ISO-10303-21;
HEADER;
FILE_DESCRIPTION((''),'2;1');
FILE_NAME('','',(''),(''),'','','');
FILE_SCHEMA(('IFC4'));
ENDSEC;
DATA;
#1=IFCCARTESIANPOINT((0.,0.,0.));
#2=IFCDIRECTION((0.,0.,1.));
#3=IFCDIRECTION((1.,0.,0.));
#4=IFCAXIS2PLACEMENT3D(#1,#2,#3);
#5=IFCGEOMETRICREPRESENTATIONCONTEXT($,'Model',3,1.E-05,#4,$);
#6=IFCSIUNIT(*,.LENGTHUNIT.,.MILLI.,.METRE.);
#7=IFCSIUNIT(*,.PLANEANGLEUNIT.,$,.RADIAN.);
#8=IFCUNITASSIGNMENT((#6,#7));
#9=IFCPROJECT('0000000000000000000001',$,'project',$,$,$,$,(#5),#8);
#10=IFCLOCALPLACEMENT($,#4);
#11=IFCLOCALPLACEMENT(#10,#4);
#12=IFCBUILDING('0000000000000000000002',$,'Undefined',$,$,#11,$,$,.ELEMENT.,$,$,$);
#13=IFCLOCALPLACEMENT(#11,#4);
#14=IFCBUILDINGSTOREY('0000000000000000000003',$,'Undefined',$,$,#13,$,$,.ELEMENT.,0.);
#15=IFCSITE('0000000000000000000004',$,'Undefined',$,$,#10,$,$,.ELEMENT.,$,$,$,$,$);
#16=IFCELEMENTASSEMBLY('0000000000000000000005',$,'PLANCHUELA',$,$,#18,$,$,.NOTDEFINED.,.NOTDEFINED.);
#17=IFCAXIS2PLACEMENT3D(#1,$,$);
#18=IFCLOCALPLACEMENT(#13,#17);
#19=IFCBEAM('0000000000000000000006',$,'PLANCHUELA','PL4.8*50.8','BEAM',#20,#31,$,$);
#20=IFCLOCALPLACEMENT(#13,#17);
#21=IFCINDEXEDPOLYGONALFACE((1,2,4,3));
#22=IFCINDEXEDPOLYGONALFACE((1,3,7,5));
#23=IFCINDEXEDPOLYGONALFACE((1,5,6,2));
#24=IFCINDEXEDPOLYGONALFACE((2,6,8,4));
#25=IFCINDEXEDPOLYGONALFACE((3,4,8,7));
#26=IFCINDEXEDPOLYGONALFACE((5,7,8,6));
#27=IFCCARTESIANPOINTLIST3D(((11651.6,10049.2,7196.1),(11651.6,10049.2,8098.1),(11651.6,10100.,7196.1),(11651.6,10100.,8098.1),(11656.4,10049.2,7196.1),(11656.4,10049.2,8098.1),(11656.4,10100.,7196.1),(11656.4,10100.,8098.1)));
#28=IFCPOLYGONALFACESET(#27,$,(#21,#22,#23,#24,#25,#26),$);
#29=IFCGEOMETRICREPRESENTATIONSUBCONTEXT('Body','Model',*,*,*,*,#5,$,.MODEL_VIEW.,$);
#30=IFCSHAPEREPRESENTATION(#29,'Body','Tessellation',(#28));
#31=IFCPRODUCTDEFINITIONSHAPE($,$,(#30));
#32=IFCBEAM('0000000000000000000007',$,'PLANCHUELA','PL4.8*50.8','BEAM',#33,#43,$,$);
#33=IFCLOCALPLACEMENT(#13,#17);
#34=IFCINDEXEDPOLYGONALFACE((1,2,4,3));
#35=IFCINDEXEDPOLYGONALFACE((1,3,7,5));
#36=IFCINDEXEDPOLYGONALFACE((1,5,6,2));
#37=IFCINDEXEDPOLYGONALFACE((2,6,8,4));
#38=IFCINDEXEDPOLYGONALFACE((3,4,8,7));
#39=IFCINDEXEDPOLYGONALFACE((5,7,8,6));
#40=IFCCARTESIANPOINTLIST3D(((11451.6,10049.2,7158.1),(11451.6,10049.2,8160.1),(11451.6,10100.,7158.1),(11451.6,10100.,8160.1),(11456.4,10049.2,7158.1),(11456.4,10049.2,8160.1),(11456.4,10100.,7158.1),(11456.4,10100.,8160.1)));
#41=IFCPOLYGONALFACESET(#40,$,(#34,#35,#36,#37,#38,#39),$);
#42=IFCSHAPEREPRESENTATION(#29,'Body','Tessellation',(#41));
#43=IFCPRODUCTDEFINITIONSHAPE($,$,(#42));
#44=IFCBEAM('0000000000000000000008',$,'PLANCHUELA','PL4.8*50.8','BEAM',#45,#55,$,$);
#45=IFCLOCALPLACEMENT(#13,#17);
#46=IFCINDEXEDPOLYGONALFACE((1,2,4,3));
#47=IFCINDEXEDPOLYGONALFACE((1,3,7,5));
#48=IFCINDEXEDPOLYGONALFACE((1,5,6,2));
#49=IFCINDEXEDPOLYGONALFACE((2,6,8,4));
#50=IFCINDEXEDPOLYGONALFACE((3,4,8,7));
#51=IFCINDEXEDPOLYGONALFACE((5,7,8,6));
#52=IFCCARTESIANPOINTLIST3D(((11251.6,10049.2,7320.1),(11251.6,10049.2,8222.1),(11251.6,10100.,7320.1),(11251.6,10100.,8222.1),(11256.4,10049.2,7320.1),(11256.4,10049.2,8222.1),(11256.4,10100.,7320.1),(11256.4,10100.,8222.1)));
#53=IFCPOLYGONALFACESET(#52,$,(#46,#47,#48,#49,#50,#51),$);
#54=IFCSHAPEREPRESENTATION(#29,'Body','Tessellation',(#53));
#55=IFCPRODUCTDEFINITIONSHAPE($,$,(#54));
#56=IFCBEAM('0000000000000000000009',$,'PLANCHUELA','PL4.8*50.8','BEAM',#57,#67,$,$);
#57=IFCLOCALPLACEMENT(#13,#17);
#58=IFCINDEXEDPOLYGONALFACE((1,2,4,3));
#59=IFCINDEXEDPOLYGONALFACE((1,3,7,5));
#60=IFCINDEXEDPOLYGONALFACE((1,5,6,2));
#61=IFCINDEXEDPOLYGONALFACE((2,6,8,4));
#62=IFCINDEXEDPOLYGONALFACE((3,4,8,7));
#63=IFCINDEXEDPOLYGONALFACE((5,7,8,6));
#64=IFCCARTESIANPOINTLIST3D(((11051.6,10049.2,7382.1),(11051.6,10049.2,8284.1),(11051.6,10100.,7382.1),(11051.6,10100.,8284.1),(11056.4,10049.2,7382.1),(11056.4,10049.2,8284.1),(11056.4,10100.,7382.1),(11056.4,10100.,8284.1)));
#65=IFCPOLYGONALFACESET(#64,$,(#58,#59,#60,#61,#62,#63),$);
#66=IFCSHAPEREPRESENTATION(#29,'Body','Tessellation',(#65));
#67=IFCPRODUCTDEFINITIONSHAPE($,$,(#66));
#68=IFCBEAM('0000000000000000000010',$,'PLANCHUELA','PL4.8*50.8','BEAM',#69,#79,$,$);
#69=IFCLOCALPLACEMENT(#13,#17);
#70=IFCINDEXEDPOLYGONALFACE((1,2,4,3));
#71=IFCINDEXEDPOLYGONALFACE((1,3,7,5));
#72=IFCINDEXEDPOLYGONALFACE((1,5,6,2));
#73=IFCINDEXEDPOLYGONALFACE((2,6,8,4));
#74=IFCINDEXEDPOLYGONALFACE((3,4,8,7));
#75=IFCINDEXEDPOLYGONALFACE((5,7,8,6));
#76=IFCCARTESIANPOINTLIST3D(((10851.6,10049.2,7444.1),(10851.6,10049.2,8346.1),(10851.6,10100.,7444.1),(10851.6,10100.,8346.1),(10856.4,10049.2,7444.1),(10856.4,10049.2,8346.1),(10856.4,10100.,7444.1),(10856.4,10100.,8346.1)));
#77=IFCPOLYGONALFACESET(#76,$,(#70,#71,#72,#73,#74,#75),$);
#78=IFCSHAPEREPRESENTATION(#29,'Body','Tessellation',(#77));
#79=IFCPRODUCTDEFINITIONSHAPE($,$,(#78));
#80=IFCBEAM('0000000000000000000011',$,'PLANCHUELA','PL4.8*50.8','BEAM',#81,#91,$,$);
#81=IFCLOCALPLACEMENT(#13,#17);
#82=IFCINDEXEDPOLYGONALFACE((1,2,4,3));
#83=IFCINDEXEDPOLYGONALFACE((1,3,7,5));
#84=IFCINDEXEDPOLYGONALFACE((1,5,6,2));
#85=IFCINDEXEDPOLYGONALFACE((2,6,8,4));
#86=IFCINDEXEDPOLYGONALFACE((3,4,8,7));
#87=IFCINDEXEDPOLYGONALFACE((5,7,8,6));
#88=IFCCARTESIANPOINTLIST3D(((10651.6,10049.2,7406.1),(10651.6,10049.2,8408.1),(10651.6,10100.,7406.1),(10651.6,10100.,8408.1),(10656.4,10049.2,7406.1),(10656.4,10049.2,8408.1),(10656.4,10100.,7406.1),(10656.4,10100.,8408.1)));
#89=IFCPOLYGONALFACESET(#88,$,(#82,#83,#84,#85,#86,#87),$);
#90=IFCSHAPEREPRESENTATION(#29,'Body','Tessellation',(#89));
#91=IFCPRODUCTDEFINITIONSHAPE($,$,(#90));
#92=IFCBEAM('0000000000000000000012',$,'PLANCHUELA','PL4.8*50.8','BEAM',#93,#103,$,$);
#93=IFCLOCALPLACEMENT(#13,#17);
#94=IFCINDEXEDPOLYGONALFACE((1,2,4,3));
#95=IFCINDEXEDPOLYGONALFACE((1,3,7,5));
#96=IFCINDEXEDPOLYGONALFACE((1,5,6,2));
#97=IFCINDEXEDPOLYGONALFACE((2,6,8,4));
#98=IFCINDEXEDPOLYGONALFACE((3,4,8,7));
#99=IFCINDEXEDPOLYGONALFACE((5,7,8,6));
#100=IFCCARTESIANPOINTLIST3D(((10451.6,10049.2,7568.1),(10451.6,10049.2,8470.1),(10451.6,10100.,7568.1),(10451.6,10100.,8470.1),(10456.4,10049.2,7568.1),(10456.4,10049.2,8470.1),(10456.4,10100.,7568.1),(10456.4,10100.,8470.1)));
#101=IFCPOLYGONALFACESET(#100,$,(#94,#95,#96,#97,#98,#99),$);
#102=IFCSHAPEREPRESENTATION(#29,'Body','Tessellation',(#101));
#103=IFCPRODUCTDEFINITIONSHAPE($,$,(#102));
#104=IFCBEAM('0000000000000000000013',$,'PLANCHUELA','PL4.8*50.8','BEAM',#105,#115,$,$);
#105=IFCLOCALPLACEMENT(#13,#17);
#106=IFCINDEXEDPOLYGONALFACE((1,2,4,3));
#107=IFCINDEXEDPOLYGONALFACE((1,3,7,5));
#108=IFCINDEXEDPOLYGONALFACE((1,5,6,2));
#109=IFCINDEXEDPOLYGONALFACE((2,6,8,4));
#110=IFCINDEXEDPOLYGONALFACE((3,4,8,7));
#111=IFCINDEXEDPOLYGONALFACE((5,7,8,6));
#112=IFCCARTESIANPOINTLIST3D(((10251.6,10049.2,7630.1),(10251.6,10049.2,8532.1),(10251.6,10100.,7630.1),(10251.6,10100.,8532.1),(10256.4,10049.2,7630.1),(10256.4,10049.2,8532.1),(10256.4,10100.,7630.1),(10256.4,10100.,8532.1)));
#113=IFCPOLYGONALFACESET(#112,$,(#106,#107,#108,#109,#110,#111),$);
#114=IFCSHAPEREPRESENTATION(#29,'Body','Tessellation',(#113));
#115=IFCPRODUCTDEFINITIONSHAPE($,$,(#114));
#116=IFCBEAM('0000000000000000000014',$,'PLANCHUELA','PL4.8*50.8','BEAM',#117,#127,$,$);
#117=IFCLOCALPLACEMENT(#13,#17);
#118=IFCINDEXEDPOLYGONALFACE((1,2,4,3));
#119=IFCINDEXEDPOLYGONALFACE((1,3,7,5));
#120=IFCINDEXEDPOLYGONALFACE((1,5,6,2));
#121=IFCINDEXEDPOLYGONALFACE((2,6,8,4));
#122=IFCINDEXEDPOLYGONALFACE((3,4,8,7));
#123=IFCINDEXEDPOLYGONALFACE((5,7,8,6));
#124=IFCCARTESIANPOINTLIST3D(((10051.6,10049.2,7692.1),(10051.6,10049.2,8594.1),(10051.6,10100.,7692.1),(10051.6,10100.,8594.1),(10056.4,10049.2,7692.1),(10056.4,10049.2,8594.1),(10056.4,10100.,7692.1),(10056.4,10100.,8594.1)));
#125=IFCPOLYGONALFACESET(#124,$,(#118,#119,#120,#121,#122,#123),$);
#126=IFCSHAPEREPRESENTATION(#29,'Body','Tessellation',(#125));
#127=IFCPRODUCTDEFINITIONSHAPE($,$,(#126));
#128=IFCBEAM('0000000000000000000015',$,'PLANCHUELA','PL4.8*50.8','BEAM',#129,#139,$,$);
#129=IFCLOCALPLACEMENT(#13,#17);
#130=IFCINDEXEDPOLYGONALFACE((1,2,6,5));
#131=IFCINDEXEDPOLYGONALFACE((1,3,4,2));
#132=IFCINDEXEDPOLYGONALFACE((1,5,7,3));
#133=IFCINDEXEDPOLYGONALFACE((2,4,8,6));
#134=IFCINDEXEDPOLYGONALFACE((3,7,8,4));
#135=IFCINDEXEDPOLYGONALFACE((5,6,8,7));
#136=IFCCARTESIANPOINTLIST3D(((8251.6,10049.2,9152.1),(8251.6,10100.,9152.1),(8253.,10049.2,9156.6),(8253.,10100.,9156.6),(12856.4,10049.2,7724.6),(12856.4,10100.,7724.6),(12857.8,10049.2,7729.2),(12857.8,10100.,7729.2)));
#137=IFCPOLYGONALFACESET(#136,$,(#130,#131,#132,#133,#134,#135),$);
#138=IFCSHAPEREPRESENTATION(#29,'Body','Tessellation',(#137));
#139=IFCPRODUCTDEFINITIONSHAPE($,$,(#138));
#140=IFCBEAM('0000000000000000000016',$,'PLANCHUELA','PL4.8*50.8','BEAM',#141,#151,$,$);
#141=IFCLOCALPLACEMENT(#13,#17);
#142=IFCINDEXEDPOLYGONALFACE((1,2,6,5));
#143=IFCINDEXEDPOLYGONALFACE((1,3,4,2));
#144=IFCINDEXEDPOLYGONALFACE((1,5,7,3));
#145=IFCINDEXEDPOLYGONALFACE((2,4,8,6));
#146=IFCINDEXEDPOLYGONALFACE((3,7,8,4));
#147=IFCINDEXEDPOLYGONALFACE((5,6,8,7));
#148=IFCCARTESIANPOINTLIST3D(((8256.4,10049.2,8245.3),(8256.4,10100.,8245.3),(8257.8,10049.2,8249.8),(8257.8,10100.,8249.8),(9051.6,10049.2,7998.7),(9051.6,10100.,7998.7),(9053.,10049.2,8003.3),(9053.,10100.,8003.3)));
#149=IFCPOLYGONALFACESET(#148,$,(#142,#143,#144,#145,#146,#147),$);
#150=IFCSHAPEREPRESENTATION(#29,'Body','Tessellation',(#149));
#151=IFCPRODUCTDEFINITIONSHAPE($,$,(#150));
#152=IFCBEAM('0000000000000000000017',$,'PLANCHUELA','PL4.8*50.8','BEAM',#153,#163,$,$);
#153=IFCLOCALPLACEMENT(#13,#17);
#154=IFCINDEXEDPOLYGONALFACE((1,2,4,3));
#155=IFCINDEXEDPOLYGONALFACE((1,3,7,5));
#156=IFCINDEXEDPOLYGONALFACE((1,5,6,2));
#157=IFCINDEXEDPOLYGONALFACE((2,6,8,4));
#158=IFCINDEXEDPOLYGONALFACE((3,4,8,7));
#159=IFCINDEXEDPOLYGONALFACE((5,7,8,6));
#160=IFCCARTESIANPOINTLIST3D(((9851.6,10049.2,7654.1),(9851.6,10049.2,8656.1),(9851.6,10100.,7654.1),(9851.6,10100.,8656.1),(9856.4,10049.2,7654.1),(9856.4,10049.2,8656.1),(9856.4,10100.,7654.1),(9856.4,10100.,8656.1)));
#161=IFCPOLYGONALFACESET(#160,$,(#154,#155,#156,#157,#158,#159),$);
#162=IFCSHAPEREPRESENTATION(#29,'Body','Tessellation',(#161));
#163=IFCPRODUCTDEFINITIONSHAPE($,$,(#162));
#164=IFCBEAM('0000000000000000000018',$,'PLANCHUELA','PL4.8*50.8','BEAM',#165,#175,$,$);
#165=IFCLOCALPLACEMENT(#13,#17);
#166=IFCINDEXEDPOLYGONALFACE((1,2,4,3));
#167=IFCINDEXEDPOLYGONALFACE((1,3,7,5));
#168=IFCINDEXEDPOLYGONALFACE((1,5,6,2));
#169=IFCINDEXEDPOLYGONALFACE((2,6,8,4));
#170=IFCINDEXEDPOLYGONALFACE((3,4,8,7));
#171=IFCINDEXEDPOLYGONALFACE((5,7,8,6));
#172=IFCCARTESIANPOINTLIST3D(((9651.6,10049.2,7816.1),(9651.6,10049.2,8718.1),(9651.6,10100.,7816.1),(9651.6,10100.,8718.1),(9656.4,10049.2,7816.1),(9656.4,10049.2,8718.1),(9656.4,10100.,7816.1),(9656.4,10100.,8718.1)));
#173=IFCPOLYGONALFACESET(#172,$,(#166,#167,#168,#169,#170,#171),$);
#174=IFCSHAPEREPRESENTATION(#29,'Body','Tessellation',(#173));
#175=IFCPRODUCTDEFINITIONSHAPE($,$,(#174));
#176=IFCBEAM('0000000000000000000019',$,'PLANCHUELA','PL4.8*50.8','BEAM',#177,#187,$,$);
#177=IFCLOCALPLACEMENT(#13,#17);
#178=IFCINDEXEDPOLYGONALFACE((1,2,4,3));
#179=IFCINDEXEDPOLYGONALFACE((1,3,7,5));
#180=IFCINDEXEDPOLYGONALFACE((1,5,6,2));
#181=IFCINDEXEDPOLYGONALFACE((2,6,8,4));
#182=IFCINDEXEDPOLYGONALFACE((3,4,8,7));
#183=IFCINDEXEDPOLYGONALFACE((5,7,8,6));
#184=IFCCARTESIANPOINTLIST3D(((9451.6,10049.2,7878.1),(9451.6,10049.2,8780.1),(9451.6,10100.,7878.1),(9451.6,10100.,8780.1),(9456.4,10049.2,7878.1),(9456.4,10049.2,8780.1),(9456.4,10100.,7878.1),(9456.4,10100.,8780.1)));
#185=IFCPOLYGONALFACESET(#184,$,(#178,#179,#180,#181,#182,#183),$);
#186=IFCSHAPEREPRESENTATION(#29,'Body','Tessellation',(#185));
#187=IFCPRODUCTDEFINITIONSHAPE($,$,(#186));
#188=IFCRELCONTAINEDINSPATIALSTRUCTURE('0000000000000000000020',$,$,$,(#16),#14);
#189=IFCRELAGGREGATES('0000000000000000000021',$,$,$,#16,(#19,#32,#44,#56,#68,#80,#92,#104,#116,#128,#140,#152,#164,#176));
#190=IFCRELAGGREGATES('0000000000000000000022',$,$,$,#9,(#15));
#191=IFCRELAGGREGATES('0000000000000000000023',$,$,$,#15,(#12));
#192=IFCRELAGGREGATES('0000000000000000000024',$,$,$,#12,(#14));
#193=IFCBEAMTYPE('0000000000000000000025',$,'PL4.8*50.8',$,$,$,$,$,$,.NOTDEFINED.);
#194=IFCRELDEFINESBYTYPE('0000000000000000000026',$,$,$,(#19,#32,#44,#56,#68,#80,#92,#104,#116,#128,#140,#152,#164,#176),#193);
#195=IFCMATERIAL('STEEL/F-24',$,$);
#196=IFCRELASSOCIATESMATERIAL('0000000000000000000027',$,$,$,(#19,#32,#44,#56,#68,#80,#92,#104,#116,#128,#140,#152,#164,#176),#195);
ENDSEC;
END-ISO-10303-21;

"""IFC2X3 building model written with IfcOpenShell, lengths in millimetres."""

from ifc_helpers import new_model, si_unit, frame, origin_with_axes, origin_2d_with_axis, place, context, subcontext, project, spatial, rectangle, extrude, material, type_object, element, aggregate, save


model = new_model("IFC2X3")

# Units and contexts
model_context = context("Model", 3, precision=1e-05, world=origin_with_axes())
body_context = subcontext(model_context, "Body", "Model", "MODEL_VIEW")
ifc_project = project(units=[si_unit("LENGTHUNIT", "METRE", prefix="MILLI"), si_unit("PLANEANGLEUNIT", "RADIAN")], contexts=[model_context])

# Site, building, storey
site_placement = place(None, origin_with_axes())
site = spatial("IfcSite", under=ifc_project, at=site_placement, Name="Undefined", CompositionType="ELEMENT")
building_placement = place(site_placement, origin_with_axes())
building = spatial("IfcBuilding", under=site, at=building_placement, Name="Undefined", CompositionType="ELEMENT")
storey_placement = place(building_placement, origin_with_axes())
storey = spatial("IfcBuildingStorey", under=building, at=storey_placement, Name="Undefined", CompositionType="ELEMENT", Elevation=0.0)

# Element assembly, beams
assembly_1_placement = place(storey_placement, origin_with_axes())
assembly_1 = element("IfcElementAssembly", 1, at=assembly_1_placement, inside=storey, Name="PLANCHUELA", AssemblyPlace="NOTDEFINED", PredefinedType="NOTDEFINED")
ifc_material_1 = material(Name="STEEL/F-24")
beam_type = type_object("IfcBeamType", Name="PL4.8*50.8", PredefinedType="NOTDEFINED")
beam_1_placement = place(assembly_1_placement, frame((11654.0, 10074.6, 8098.1), z_axis=(0.0, -1.0, 0.0), x_axis=(0.0, 0.0, -1.0)))
beam_1 = element("IfcBeam", 2, at=beam_1_placement, type_object=beam_type, material=ifc_material_1, Name="PLANCHUELA", Description="PL4.8*50.8", ObjectType="BEAM", context=body_context, shape_type="SweptSolid", body=[
    extrude(rectangle(XDim=4.8, YDim=50.8, at=origin_2d_with_axis()), frame((902.0, 0.0, 0.0), z_axis=(-1.0, 0.0, 0.0), x_axis=(0.0, -1.0, 0.0)), (0.0, 0.0, 1.0), 902.0),
])
beam_2_placement = place(assembly_1_placement, frame((11454.0, 10074.6, 8160.1), z_axis=(0.0, -1.0, 0.0), x_axis=(0.0, 0.0, -1.0)))
beam_2 = element("IfcBeam", 3, at=beam_2_placement, type_object=beam_type, material=ifc_material_1, Name="PLANCHUELA", Description="PL4.8*50.8", ObjectType="BEAM", context=body_context, shape_type="SweptSolid", body=[
    extrude(rectangle(XDim=4.8, YDim=50.8, at=origin_2d_with_axis()), frame((1002.0, 0.0, 0.0), z_axis=(-1.0, 0.0, 0.0), x_axis=(0.0, -1.0, 0.0)), (0.0, 0.0, 1.0), 1002.0),
])
beam_3_placement = place(assembly_1_placement, frame((11254.0, 10074.6, 8222.1), z_axis=(0.0, -1.0, 0.0), x_axis=(0.0, 0.0, -1.0)))
beam_3 = element("IfcBeam", 4, at=beam_3_placement, type_object=beam_type, material=ifc_material_1, Name="PLANCHUELA", Description="PL4.8*50.8", ObjectType="BEAM", context=body_context, shape_type="SweptSolid", body=[
    extrude(rectangle(XDim=4.8, YDim=50.8, at=origin_2d_with_axis()), frame((902.0, 0.0, 0.0), z_axis=(-1.0, 0.0, 0.0), x_axis=(0.0, -1.0, 0.0)), (0.0, 0.0, 1.0), 902.0),
])
beam_4_placement = place(assembly_1_placement, frame((11054.0, 10074.6, 8284.1), z_axis=(0.0, -1.0, 0.0), x_axis=(0.0, 0.0, -1.0)))
beam_4 = element("IfcBeam", 5, at=beam_4_placement, type_object=beam_type, material=ifc_material_1, Name="PLANCHUELA", Description="PL4.8*50.8", ObjectType="BEAM", context=body_context, shape_type="SweptSolid", body=[
    extrude(rectangle(XDim=4.8, YDim=50.8, at=origin_2d_with_axis()), frame((902.0, 0.0, 0.0), z_axis=(-1.0, 0.0, 0.0), x_axis=(0.0, -1.0, 0.0)), (0.0, 0.0, 1.0), 902.0),
])
beam_5_placement = place(assembly_1_placement, frame((10854.0, 10074.6, 8346.1), z_axis=(0.0, -1.0, 0.0), x_axis=(0.0, 0.0, -1.0)))
beam_5 = element("IfcBeam", 6, at=beam_5_placement, type_object=beam_type, material=ifc_material_1, Name="PLANCHUELA", Description="PL4.8*50.8", ObjectType="BEAM", context=body_context, shape_type="SweptSolid", body=[
    extrude(rectangle(XDim=4.8, YDim=50.8, at=origin_2d_with_axis()), frame((902.0, 0.0, 0.0), z_axis=(-1.0, 0.0, 0.0), x_axis=(0.0, -1.0, 0.0)), (0.0, 0.0, 1.0), 902.0),
])
beam_6_placement = place(assembly_1_placement, frame((10654.0, 10074.6, 8408.1), z_axis=(0.0, -1.0, 0.0), x_axis=(0.0, 0.0, -1.0)))
beam_6 = element("IfcBeam", 7, at=beam_6_placement, type_object=beam_type, material=ifc_material_1, Name="PLANCHUELA", Description="PL4.8*50.8", ObjectType="BEAM", context=body_context, shape_type="SweptSolid", body=[
    extrude(rectangle(XDim=4.8, YDim=50.8, at=origin_2d_with_axis()), frame((1002.0, 0.0, 0.0), z_axis=(-1.0, 0.0, 0.0), x_axis=(0.0, -1.0, 0.0)), (0.0, 0.0, 1.0), 1002.0),
])
beam_7_placement = place(assembly_1_placement, frame((10454.0, 10074.6, 8470.1), z_axis=(0.0, -1.0, 0.0), x_axis=(0.0, 0.0, -1.0)))
beam_7 = element("IfcBeam", 8, at=beam_7_placement, type_object=beam_type, material=ifc_material_1, Name="PLANCHUELA", Description="PL4.8*50.8", ObjectType="BEAM", context=body_context, shape_type="SweptSolid", body=[
    extrude(rectangle(XDim=4.8, YDim=50.8, at=origin_2d_with_axis()), frame((902.0, 0.0, 0.0), z_axis=(-1.0, 0.0, 0.0), x_axis=(0.0, -1.0, 0.0)), (0.0, 0.0, 1.0), 902.0),
])
beam_8_placement = place(assembly_1_placement, frame((10254.0, 10074.6, 8532.1), z_axis=(0.0, -1.0, 0.0), x_axis=(0.0, 0.0, -1.0)))
beam_8 = element("IfcBeam", 9, at=beam_8_placement, type_object=beam_type, material=ifc_material_1, Name="PLANCHUELA", Description="PL4.8*50.8", ObjectType="BEAM", context=body_context, shape_type="SweptSolid", body=[
    extrude(rectangle(XDim=4.8, YDim=50.8, at=origin_2d_with_axis()), frame((902.0, 0.0, 0.0), z_axis=(-1.0, 0.0, 0.0), x_axis=(0.0, -1.0, 0.0)), (0.0, 0.0, 1.0), 902.0),
])
beam_9_placement = place(assembly_1_placement, frame((10054.0, 10074.6, 8594.1), z_axis=(0.0, -1.0, 0.0), x_axis=(0.0, 0.0, -1.0)))
beam_9 = element("IfcBeam", 10, at=beam_9_placement, type_object=beam_type, material=ifc_material_1, Name="PLANCHUELA", Description="PL4.8*50.8", ObjectType="BEAM", context=body_context, shape_type="SweptSolid", body=[
    extrude(rectangle(XDim=4.8, YDim=50.8, at=origin_2d_with_axis()), frame((902.0, 0.0, 0.0), z_axis=(-1.0, 0.0, 0.0), x_axis=(0.0, -1.0, 0.0)), (0.0, 0.0, 1.0), 902.0),
])
beam_10_placement = place(assembly_1_placement, frame((8252.3, 10074.6, 9154.3), z_axis=(0.0, -1.0, 0.0), x_axis=(0.955157, 0.0, -0.296099)))
beam_10 = element("IfcBeam", 11, at=beam_10_placement, type_object=beam_type, material=ifc_material_1, Name="PLANCHUELA", Description="PL4.8*50.8", ObjectType="BEAM", context=body_context, shape_type="SweptSolid", body=[
    extrude(rectangle(XDim=4.8, YDim=50.8, at=origin_2d_with_axis()), frame((4821.0, 0.0, 0.0), z_axis=(-1.0, 0.0, 0.0), x_axis=(0.0, -1.0, 0.0)), (0.0, 0.0, 1.0), 4821.0),
])
beam_11_placement = place(assembly_1_placement, frame((8257.1, 10074.6, 8247.5), z_axis=(0.0, -1.0, 0.0), x_axis=(0.955157, 0.0, -0.296099)))
beam_11 = element("IfcBeam", 12, at=beam_11_placement, type_object=beam_type, material=ifc_material_1, Name="PLANCHUELA", Description="PL4.8*50.8", ObjectType="BEAM", context=body_context, shape_type="SweptSolid", body=[
    extrude(rectangle(XDim=4.8, YDim=50.8, at=origin_2d_with_axis()), frame((832.5, 0.0, 0.0), z_axis=(-1.0, 0.0, 0.0), x_axis=(0.0, -1.0, 0.0)), (0.0, 0.0, 1.0), 832.5),
])
beam_12_placement = place(assembly_1_placement, frame((9854.0, 10074.6, 8656.1), z_axis=(0.0, -1.0, 0.0), x_axis=(0.0, 0.0, -1.0)))
beam_12 = element("IfcBeam", 13, at=beam_12_placement, type_object=beam_type, material=ifc_material_1, Name="PLANCHUELA", Description="PL4.8*50.8", ObjectType="BEAM", context=body_context, shape_type="SweptSolid", body=[
    extrude(rectangle(XDim=4.8, YDim=50.8, at=origin_2d_with_axis()), frame((1002.0, 0.0, 0.0), z_axis=(-1.0, 0.0, 0.0), x_axis=(0.0, -1.0, 0.0)), (0.0, 0.0, 1.0), 1002.0),
])
beam_13_placement = place(assembly_1_placement, frame((9654.0, 10074.6, 8718.1), z_axis=(0.0, -1.0, 0.0), x_axis=(0.0, 0.0, -1.0)))
beam_13 = element("IfcBeam", 14, at=beam_13_placement, type_object=beam_type, material=ifc_material_1, Name="PLANCHUELA", Description="PL4.8*50.8", ObjectType="BEAM", context=body_context, shape_type="SweptSolid", body=[
    extrude(rectangle(XDim=4.8, YDim=50.8, at=origin_2d_with_axis()), frame((902.0, 0.0, 0.0), z_axis=(-1.0, 0.0, 0.0), x_axis=(0.0, -1.0, 0.0)), (0.0, 0.0, 1.0), 902.0),
])
beam_14_placement = place(assembly_1_placement, frame((9454.0, 10074.6, 8780.1), z_axis=(0.0, -1.0, 0.0), x_axis=(0.0, 0.0, -1.0)))
beam_14 = element("IfcBeam", 15, at=beam_14_placement, type_object=beam_type, material=ifc_material_1, Name="PLANCHUELA", Description="PL4.8*50.8", ObjectType="BEAM", context=body_context, shape_type="SweptSolid", body=[
    extrude(rectangle(XDim=4.8, YDim=50.8, at=origin_2d_with_axis()), frame((902.0, 0.0, 0.0), z_axis=(-1.0, 0.0, 0.0), x_axis=(0.0, -1.0, 0.0)), (0.0, 0.0, 1.0), 902.0),
])
aggregate(assembly_1, [beam_1, beam_2, beam_3, beam_4, beam_5, beam_6, beam_7, beam_8, beam_9, beam_10, beam_11, beam_12, beam_13, beam_14])

save(model, "model.ifc")
